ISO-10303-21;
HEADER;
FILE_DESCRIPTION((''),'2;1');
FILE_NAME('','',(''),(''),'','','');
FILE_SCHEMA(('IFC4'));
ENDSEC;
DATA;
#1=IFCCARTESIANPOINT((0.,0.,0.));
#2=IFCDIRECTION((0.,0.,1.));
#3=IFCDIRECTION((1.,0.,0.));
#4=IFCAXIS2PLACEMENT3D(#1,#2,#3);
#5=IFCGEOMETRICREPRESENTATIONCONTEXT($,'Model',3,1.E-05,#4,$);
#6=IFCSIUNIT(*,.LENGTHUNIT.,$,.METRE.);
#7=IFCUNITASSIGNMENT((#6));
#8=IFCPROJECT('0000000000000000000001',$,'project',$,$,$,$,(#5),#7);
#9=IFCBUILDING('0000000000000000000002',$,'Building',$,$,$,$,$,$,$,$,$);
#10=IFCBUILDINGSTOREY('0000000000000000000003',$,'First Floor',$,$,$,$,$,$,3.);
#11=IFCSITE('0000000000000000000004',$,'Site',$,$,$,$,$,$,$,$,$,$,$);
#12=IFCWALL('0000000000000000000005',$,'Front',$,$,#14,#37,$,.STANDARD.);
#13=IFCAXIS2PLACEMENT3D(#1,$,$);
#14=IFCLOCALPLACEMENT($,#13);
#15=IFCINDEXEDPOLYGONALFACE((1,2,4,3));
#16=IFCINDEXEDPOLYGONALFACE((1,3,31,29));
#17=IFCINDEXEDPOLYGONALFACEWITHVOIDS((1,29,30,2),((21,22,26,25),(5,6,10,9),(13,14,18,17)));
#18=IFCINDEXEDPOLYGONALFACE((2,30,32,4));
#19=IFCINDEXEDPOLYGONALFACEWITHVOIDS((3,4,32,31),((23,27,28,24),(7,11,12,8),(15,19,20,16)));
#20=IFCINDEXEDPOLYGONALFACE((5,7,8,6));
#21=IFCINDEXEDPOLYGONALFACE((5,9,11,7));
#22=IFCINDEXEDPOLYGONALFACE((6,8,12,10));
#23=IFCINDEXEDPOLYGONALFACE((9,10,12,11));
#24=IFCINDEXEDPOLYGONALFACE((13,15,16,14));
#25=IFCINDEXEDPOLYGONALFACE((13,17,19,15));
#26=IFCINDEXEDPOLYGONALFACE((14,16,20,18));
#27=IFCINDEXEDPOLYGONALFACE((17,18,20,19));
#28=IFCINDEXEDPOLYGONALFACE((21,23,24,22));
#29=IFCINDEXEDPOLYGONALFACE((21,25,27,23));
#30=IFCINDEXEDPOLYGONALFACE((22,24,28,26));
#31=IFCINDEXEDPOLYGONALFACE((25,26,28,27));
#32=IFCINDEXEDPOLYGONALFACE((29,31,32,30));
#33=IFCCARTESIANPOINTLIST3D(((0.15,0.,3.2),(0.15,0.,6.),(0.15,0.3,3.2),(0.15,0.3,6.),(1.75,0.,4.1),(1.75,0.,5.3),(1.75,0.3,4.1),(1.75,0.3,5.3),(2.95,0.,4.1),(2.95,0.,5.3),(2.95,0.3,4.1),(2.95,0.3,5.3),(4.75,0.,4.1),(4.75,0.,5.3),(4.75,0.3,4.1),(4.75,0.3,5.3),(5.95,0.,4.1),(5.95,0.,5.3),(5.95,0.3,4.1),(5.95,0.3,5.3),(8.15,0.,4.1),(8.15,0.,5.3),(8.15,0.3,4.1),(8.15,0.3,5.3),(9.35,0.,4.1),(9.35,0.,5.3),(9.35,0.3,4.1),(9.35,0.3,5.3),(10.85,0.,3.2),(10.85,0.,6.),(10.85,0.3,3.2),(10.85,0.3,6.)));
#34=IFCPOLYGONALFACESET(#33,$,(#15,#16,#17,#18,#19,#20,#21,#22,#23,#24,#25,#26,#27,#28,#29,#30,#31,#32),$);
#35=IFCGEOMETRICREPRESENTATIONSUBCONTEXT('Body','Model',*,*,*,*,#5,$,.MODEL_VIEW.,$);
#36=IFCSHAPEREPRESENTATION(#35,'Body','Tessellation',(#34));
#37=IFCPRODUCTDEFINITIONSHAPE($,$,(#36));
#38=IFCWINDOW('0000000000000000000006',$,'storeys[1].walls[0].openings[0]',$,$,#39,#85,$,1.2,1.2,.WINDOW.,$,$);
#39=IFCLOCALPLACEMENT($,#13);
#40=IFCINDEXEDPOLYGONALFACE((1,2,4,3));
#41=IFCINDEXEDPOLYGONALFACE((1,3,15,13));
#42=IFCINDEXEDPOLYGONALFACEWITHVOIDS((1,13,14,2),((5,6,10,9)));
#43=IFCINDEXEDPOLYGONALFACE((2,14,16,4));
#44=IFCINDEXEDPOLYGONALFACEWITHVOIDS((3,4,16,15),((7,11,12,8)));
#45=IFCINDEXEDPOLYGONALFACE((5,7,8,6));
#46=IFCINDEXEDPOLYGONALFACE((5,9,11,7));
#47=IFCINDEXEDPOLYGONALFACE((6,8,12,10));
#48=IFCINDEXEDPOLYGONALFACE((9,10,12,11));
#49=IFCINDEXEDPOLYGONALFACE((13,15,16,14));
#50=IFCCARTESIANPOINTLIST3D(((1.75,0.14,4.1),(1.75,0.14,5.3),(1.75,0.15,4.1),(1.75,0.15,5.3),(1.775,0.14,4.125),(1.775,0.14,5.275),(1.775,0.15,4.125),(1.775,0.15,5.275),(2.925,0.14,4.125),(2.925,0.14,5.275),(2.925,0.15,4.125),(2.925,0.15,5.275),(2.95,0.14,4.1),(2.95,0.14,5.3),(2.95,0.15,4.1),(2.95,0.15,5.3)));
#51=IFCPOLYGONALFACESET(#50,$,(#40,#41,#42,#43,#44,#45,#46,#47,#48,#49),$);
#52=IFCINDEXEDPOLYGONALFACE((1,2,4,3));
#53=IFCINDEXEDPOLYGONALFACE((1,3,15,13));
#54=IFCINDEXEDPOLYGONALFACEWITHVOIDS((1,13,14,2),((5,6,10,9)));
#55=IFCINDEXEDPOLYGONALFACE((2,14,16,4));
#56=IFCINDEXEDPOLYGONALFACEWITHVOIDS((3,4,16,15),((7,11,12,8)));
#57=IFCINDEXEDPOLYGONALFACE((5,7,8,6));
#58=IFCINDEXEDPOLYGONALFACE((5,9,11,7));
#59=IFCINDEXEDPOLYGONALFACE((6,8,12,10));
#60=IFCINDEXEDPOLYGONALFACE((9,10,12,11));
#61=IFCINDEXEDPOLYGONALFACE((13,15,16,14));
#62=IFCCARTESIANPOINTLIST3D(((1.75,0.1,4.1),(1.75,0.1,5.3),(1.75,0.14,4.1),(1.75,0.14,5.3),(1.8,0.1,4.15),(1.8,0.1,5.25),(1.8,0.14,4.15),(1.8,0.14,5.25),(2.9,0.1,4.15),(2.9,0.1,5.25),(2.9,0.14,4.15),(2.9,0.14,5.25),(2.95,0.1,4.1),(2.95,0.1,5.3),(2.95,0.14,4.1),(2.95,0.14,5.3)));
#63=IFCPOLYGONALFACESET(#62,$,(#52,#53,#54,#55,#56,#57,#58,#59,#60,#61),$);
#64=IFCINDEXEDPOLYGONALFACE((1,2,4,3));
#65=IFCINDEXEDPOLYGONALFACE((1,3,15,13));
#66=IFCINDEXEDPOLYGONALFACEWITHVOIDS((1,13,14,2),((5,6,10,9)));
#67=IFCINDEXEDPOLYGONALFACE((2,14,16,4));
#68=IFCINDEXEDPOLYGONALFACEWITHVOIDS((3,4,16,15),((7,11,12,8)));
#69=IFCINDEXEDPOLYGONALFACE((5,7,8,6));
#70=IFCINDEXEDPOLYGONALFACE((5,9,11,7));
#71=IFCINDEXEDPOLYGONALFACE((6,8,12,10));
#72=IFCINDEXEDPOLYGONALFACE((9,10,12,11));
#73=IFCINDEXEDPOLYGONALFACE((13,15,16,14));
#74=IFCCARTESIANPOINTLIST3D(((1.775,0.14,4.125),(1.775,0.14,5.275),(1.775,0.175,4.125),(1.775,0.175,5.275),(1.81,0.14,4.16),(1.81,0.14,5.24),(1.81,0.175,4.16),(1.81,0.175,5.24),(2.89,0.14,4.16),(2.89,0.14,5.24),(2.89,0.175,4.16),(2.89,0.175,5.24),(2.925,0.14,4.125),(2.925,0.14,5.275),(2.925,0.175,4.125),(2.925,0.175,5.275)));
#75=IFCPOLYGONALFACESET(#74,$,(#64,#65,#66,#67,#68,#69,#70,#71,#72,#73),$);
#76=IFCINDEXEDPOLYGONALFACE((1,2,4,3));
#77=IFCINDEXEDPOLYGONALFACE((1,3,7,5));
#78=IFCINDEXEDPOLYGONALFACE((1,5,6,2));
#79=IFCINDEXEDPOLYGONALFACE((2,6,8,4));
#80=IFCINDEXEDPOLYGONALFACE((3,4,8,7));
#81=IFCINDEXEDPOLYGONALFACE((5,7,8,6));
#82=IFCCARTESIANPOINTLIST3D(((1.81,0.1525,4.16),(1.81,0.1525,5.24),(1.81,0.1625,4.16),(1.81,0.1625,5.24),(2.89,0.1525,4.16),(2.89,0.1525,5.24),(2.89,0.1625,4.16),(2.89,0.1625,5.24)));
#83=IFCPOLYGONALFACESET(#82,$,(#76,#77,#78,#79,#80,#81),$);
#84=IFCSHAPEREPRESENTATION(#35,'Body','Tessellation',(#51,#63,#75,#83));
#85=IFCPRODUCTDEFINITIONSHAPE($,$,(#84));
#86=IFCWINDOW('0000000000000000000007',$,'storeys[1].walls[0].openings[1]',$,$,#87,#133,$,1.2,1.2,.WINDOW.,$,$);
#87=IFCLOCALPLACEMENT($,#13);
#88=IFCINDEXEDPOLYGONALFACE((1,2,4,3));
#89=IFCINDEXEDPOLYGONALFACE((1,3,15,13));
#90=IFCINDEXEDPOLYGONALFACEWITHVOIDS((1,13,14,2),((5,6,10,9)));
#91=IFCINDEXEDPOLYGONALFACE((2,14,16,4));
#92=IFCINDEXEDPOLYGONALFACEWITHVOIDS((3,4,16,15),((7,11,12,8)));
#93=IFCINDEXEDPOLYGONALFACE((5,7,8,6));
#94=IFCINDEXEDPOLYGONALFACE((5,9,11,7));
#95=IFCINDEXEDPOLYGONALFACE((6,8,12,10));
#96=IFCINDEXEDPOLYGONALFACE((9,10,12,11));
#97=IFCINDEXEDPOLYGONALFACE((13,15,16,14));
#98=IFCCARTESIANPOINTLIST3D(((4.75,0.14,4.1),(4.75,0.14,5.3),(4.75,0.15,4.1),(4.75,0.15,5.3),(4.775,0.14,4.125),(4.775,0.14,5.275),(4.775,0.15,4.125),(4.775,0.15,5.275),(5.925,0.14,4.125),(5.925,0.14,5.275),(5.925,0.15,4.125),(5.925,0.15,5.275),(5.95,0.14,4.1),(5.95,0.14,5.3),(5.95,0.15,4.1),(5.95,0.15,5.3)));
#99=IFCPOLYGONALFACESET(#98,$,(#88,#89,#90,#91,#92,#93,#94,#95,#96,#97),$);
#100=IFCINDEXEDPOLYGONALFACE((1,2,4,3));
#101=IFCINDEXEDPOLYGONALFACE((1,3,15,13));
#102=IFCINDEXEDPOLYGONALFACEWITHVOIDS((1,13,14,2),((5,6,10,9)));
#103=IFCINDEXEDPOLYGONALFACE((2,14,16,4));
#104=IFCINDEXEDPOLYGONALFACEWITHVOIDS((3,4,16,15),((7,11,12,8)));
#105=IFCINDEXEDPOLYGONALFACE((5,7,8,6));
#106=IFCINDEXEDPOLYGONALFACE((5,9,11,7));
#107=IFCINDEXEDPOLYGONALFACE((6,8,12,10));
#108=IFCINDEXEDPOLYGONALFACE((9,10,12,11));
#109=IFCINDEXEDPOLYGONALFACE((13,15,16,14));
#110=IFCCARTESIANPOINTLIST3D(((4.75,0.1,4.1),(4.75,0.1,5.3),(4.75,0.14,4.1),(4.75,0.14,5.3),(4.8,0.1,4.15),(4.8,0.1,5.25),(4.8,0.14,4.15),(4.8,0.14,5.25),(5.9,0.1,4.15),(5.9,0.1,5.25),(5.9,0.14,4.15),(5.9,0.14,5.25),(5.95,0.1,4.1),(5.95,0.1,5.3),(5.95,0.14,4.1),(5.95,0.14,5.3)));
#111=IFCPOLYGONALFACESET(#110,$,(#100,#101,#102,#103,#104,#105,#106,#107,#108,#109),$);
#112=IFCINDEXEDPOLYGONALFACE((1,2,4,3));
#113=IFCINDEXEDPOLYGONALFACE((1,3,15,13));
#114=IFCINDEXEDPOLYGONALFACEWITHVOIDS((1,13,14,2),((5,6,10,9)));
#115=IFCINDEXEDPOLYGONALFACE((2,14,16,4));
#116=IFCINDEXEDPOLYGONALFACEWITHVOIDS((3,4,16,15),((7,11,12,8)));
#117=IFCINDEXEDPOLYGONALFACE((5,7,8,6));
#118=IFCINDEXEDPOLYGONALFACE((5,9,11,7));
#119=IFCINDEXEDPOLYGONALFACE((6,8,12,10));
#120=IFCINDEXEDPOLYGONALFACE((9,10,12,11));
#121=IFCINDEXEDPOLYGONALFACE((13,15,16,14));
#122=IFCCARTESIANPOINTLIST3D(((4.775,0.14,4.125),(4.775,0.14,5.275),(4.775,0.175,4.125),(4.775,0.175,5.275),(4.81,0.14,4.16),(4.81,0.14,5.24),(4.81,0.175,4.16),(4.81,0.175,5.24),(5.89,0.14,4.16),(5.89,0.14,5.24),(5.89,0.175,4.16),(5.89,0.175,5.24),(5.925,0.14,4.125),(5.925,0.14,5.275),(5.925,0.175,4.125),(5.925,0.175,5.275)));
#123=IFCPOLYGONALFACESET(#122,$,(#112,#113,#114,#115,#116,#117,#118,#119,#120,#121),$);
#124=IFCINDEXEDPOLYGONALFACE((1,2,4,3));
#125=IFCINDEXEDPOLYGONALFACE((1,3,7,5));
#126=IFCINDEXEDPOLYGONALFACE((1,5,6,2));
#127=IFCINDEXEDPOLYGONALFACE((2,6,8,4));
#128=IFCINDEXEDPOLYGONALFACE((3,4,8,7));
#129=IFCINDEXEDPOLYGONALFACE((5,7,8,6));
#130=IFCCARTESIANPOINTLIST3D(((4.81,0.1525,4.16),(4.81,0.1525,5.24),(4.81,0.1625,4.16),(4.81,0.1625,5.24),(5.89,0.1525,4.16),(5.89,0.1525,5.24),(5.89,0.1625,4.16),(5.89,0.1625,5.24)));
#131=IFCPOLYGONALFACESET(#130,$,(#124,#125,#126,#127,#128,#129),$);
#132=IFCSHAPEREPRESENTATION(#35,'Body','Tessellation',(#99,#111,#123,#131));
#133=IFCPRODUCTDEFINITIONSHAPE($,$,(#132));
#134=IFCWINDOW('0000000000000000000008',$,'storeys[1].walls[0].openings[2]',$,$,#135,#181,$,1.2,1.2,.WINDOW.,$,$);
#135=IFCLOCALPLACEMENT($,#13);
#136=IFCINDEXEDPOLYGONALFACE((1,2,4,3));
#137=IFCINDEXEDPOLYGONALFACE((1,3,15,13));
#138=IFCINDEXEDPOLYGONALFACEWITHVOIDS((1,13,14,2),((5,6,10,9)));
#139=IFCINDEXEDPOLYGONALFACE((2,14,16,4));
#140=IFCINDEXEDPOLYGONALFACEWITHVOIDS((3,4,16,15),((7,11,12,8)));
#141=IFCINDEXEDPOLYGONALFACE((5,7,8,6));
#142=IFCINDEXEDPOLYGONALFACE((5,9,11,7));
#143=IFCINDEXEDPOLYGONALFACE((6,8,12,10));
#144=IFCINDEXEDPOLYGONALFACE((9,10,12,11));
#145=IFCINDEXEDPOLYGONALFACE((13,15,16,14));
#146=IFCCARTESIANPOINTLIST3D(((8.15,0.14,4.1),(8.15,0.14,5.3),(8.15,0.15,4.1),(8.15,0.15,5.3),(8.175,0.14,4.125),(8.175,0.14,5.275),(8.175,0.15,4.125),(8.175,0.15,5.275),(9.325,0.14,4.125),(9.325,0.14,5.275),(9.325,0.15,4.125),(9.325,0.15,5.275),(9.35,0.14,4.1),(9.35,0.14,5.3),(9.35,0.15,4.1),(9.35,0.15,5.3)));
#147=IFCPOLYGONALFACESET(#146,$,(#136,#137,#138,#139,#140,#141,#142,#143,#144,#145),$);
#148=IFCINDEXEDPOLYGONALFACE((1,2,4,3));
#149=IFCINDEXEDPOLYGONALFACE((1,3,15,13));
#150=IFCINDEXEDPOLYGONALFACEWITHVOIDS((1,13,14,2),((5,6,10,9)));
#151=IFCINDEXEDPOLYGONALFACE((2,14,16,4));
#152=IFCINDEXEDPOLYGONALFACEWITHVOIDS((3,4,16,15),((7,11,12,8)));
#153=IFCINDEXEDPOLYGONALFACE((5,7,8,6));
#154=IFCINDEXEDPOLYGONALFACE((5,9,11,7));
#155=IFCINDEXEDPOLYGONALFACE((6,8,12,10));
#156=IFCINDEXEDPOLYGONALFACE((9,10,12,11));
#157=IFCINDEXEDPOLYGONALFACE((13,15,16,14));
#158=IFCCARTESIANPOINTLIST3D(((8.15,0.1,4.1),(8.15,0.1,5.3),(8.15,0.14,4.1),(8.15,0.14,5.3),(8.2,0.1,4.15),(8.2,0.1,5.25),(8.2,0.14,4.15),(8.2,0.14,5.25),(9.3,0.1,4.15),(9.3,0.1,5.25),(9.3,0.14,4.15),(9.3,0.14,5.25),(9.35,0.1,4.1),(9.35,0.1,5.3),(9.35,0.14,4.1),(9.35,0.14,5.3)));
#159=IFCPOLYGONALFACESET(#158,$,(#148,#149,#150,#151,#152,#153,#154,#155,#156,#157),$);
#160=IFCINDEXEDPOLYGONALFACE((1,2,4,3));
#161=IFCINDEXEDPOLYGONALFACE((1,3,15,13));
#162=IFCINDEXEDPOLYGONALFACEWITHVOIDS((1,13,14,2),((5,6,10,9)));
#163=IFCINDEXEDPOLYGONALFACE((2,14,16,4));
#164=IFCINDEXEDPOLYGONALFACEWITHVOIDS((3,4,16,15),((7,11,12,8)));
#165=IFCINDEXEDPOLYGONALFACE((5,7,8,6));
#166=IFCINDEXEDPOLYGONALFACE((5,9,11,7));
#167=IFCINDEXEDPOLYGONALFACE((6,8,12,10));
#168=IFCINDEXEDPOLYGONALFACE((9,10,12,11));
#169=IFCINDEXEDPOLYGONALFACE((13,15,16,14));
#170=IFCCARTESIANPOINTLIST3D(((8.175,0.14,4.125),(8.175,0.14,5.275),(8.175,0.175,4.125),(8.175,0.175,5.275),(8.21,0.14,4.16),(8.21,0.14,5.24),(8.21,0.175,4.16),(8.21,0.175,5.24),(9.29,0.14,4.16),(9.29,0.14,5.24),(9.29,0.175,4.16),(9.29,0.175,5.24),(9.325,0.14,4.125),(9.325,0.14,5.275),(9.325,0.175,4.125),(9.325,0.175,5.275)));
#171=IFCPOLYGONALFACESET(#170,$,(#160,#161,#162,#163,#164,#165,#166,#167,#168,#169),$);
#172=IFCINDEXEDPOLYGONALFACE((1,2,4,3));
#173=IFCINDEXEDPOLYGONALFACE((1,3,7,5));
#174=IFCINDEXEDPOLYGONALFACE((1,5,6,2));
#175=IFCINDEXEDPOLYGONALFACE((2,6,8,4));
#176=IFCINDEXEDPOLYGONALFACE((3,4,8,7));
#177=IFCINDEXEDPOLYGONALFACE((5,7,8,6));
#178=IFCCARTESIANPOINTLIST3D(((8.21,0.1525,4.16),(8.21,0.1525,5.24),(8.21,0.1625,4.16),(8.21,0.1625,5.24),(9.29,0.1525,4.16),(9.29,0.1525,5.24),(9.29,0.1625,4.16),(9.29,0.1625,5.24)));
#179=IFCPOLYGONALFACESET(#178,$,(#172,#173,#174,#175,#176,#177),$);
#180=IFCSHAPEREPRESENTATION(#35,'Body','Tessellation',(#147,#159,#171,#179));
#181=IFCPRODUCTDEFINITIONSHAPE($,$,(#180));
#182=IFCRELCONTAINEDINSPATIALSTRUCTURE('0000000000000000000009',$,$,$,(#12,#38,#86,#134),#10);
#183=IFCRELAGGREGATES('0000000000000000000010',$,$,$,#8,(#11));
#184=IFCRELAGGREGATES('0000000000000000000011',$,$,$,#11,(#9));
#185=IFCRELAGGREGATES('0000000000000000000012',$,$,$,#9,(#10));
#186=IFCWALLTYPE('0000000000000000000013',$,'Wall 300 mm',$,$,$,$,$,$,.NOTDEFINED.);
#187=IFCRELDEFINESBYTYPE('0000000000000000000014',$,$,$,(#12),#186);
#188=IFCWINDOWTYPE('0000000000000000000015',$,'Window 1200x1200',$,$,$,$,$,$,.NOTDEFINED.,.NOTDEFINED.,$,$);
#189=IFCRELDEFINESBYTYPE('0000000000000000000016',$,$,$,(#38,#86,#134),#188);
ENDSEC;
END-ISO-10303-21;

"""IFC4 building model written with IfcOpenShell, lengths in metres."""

from ifc_helpers import new_model, si_unit, frame, origin_with_axes, place, context, subcontext, project, spatial, line, indexed_curve, outline, extrude, type_object, element, fill, save


model = new_model("IFC4")

# Units and contexts
model_context = context("Model", 3, precision=1e-05, world=origin_with_axes())
body_context = subcontext(model_context, "Body", "Model", "MODEL_VIEW")
ifc_project = project(units=[si_unit("LENGTHUNIT", "METRE")], contexts=[model_context])

# Site, building, storey
site = spatial("IfcSite", under=ifc_project, Name="Site")
building = spatial("IfcBuilding", under=site, Name="Building")
storey = spatial("IfcBuildingStorey", under=building, Name="First Floor", Elevation=3.0)

# Wall, openings, windows
wall_type_1 = type_object("IfcWallType", Name="Wall 300 mm", PredefinedType="NOTDEFINED")
wall_1_placement = place(None, frame((0.15, 0.15, 3.2), z_axis=(0.0, 0.0, 1.0), x_axis=(1.0, 0.0, 0.0)))
wall_1 = element("IfcWall", 1, at=wall_1_placement, inside=storey, type_object=wall_type_1, Name="Front", PredefinedType="STANDARD", context=body_context, shape_type="SweptSolid", body=[
    extrude(outline(indexed_curve([(0.0, 0.0), (0.0, 0.3), (10.7, 0.3), (10.7, 0.0), (0.0, 0.0)], self_intersect=False)), frame((0.0, -0.15, 0.0), z_axis=(0.0, 0.0, 1.0), x_axis=(1.0, 0.0, 0.0)), (0.0, 0.0, 1.0), 2.8),
])
opening_1_placement = place(wall_1_placement, frame((1.6, -0.16, 0.9), z_axis=(0.0, 0.0, 1.0), x_axis=(1.0, 0.0, 0.0)))
opening_1 = element("IfcOpeningElement", 2, at=opening_1_placement, cuts=wall_1, context=body_context, shape_type="SweptSolid", body=[
    extrude(outline(indexed_curve([(0.0, 0.0), (0.0, 0.32), (1.2, 0.32), (1.2, 0.0), (0.0, 0.0)], self_intersect=False)), origin_with_axes(), (0.0, 0.0, 1.0), 1.2),
])
opening_2_placement = place(wall_1_placement, frame((4.6, -0.16, 0.9), z_axis=(0.0, 0.0, 1.0), x_axis=(1.0, 0.0, 0.0)))
opening_2 = element("IfcOpeningElement", 3, at=opening_2_placement, cuts=wall_1, context=body_context, shape_type="SweptSolid", body=[
    extrude(outline(indexed_curve([(0.0, 0.0), (0.0, 0.32), (1.2, 0.32), (1.2, 0.0), (0.0, 0.0)], self_intersect=False)), origin_with_axes(), (0.0, 0.0, 1.0), 1.2),
])
opening_3_placement = place(wall_1_placement, frame((8.0, -0.16, 0.9), z_axis=(0.0, 0.0, 1.0), x_axis=(1.0, 0.0, 0.0)))
opening_3 = element("IfcOpeningElement", 4, at=opening_3_placement, cuts=wall_1, context=body_context, shape_type="SweptSolid", body=[
    extrude(outline(indexed_curve([(0.0, 0.0), (0.0, 0.32), (1.2, 0.32), (1.2, 0.0), (0.0, 0.0)], self_intersect=False)), origin_with_axes(), (0.0, 0.0, 1.0), 1.2),
])
window_type_1 = type_object("IfcWindowType", Name="Window 1200x1200", PartitioningType="NOTDEFINED", PredefinedType="NOTDEFINED")
window_1_placement = place(None, frame((1.75, 0.05, 4.1), z_axis=(0.0, 0.0, 1.0), x_axis=(1.0, 0.0, 0.0)))
window_1 = element("IfcWindow", 5, at=window_1_placement, inside=storey, type_object=window_type_1, Name="storeys[1].walls[0].openings[0]", OverallHeight=1.2, OverallWidth=1.2, PredefinedType="WINDOW", context=body_context, shape_type="SweptSolid", body=[
    extrude(outline(indexed_curve([(0.0, 0.0), (1.2, 0.0), (1.2, 1.2), (0.0, 1.2)], segments=[line(1, 2, 3, 4, 1)]), holes=[indexed_curve([(0.025, 0.025), (1.175, 0.025), (1.175, 1.175), (0.025, 1.175)], segments=[line(1, 2, 3, 4, 1)])]), frame((0.0, 0.09, 0.0), z_axis=(0.0, -1.0, 0.0), x_axis=(1.0, 0.0, 0.0)), (0.0, 0.0, -1.0), 0.01),
    extrude(outline(indexed_curve([(0.0, 0.0), (1.2, 0.0), (1.2, 1.2), (0.0, 1.2)], segments=[line(1, 2, 3, 4, 1)]), holes=[indexed_curve([(0.05, 0.05), (1.15, 0.05), (1.15, 1.15), (0.05, 1.15)], segments=[line(1, 2, 3, 4, 1)])]), frame((0.0, 0.05, 0.0), z_axis=(0.0, -1.0, 0.0), x_axis=(1.0, 0.0, 0.0)), (0.0, 0.0, -1.0), 0.04),
    extrude(outline(indexed_curve([(0.0, 0.0), (1.15, 0.0), (1.15, 1.15), (0.0, 1.15)], segments=[line(1, 2, 3, 4, 1)]), holes=[indexed_curve([(0.035, 0.035), (1.115, 0.035), (1.115, 1.115), (0.035, 1.115)], segments=[line(1, 2, 3, 4, 1)])]), frame((0.025, 0.09, 0.025), z_axis=(0.0, -1.0, 0.0), x_axis=(1.0, 0.0, 0.0)), (0.0, 0.0, -1.0), 0.035),
    extrude(outline(indexed_curve([(0.035, 0.035), (1.115, 0.035), (1.115, 1.115), (0.035, 1.115)], segments=[line(1, 2, 3, 4, 1)])), frame((0.025, 0.1025, 0.025), z_axis=(0.0, -1.0, 0.0), x_axis=(1.0, 0.0, 0.0)), (0.0, 0.0, -1.0), 0.01),
])
fill(opening_1, window_1)
window_2_placement = place(None, frame((4.75, 0.05, 4.1), z_axis=(0.0, 0.0, 1.0), x_axis=(1.0, 0.0, 0.0)))
window_2 = element("IfcWindow", 6, at=window_2_placement, inside=storey, type_object=window_type_1, Name="storeys[1].walls[0].openings[1]", OverallHeight=1.2, OverallWidth=1.2, PredefinedType="WINDOW", context=body_context, shape_type="SweptSolid", body=[
    extrude(outline(indexed_curve([(0.0, 0.0), (1.2, 0.0), (1.2, 1.2), (0.0, 1.2)], segments=[line(1, 2, 3, 4, 1)]), holes=[indexed_curve([(0.025, 0.025), (1.175, 0.025), (1.175, 1.175), (0.025, 1.175)], segments=[line(1, 2, 3, 4, 1)])]), frame((0.0, 0.09, 0.0), z_axis=(0.0, -1.0, 0.0), x_axis=(1.0, 0.0, 0.0)), (0.0, 0.0, -1.0), 0.01),
    extrude(outline(indexed_curve([(0.0, 0.0), (1.2, 0.0), (1.2, 1.2), (0.0, 1.2)], segments=[line(1, 2, 3, 4, 1)]), holes=[indexed_curve([(0.05, 0.05), (1.15, 0.05), (1.15, 1.15), (0.05, 1.15)], segments=[line(1, 2, 3, 4, 1)])]), frame((0.0, 0.05, 0.0), z_axis=(0.0, -1.0, 0.0), x_axis=(1.0, 0.0, 0.0)), (0.0, 0.0, -1.0), 0.04),
    extrude(outline(indexed_curve([(0.0, 0.0), (1.15, 0.0), (1.15, 1.15), (0.0, 1.15)], segments=[line(1, 2, 3, 4, 1)]), holes=[indexed_curve([(0.035, 0.035), (1.115, 0.035), (1.115, 1.115), (0.035, 1.115)], segments=[line(1, 2, 3, 4, 1)])]), frame((0.025, 0.09, 0.025), z_axis=(0.0, -1.0, 0.0), x_axis=(1.0, 0.0, 0.0)), (0.0, 0.0, -1.0), 0.035),
    extrude(outline(indexed_curve([(0.035, 0.035), (1.115, 0.035), (1.115, 1.115), (0.035, 1.115)], segments=[line(1, 2, 3, 4, 1)])), frame((0.025, 0.1025, 0.025), z_axis=(0.0, -1.0, 0.0), x_axis=(1.0, 0.0, 0.0)), (0.0, 0.0, -1.0), 0.01),
])
fill(opening_2, window_2)
window_3_placement = place(None, frame((8.15, 0.05, 4.1), z_axis=(0.0, 0.0, 1.0), x_axis=(1.0, 0.0, 0.0)))
window_3 = element("IfcWindow", 7, at=window_3_placement, inside=storey, type_object=window_type_1, Name="storeys[1].walls[0].openings[2]", OverallHeight=1.2, OverallWidth=1.2, PredefinedType="WINDOW", context=body_context, shape_type="SweptSolid", body=[
    extrude(outline(indexed_curve([(0.0, 0.0), (1.2, 0.0), (1.2, 1.2), (0.0, 1.2)], segments=[line(1, 2, 3, 4, 1)]), holes=[indexed_curve([(0.025, 0.025), (1.175, 0.025), (1.175, 1.175), (0.025, 1.175)], segments=[line(1, 2, 3, 4, 1)])]), frame((0.0, 0.09, 0.0), z_axis=(0.0, -1.0, 0.0), x_axis=(1.0, 0.0, 0.0)), (0.0, 0.0, -1.0), 0.01),
    extrude(outline(indexed_curve([(0.0, 0.0), (1.2, 0.0), (1.2, 1.2), (0.0, 1.2)], segments=[line(1, 2, 3, 4, 1)]), holes=[indexed_curve([(0.05, 0.05), (1.15, 0.05), (1.15, 1.15), (0.05, 1.15)], segments=[line(1, 2, 3, 4, 1)])]), frame((0.0, 0.05, 0.0), z_axis=(0.0, -1.0, 0.0), x_axis=(1.0, 0.0, 0.0)), (0.0, 0.0, -1.0), 0.04),
    extrude(outline(indexed_curve([(0.0, 0.0), (1.15, 0.0), (1.15, 1.15), (0.0, 1.15)], segments=[line(1, 2, 3, 4, 1)]), holes=[indexed_curve([(0.035, 0.035), (1.115, 0.035), (1.115, 1.115), (0.035, 1.115)], segments=[line(1, 2, 3, 4, 1)])]), frame((0.025, 0.09, 0.025), z_axis=(0.0, -1.0, 0.0), x_axis=(1.0, 0.0, 0.0)), (0.0, 0.0, -1.0), 0.035),
    extrude(outline(indexed_curve([(0.035, 0.035), (1.115, 0.035), (1.115, 1.115), (0.035, 1.115)], segments=[line(1, 2, 3, 4, 1)])), frame((0.025, 0.1025, 0.025), z_axis=(0.0, -1.0, 0.0), x_axis=(1.0, 0.0, 0.0)), (0.0, 0.0, -1.0), 0.01),
])
fill(opening_3, window_3)

save(model, "model.ifc")
